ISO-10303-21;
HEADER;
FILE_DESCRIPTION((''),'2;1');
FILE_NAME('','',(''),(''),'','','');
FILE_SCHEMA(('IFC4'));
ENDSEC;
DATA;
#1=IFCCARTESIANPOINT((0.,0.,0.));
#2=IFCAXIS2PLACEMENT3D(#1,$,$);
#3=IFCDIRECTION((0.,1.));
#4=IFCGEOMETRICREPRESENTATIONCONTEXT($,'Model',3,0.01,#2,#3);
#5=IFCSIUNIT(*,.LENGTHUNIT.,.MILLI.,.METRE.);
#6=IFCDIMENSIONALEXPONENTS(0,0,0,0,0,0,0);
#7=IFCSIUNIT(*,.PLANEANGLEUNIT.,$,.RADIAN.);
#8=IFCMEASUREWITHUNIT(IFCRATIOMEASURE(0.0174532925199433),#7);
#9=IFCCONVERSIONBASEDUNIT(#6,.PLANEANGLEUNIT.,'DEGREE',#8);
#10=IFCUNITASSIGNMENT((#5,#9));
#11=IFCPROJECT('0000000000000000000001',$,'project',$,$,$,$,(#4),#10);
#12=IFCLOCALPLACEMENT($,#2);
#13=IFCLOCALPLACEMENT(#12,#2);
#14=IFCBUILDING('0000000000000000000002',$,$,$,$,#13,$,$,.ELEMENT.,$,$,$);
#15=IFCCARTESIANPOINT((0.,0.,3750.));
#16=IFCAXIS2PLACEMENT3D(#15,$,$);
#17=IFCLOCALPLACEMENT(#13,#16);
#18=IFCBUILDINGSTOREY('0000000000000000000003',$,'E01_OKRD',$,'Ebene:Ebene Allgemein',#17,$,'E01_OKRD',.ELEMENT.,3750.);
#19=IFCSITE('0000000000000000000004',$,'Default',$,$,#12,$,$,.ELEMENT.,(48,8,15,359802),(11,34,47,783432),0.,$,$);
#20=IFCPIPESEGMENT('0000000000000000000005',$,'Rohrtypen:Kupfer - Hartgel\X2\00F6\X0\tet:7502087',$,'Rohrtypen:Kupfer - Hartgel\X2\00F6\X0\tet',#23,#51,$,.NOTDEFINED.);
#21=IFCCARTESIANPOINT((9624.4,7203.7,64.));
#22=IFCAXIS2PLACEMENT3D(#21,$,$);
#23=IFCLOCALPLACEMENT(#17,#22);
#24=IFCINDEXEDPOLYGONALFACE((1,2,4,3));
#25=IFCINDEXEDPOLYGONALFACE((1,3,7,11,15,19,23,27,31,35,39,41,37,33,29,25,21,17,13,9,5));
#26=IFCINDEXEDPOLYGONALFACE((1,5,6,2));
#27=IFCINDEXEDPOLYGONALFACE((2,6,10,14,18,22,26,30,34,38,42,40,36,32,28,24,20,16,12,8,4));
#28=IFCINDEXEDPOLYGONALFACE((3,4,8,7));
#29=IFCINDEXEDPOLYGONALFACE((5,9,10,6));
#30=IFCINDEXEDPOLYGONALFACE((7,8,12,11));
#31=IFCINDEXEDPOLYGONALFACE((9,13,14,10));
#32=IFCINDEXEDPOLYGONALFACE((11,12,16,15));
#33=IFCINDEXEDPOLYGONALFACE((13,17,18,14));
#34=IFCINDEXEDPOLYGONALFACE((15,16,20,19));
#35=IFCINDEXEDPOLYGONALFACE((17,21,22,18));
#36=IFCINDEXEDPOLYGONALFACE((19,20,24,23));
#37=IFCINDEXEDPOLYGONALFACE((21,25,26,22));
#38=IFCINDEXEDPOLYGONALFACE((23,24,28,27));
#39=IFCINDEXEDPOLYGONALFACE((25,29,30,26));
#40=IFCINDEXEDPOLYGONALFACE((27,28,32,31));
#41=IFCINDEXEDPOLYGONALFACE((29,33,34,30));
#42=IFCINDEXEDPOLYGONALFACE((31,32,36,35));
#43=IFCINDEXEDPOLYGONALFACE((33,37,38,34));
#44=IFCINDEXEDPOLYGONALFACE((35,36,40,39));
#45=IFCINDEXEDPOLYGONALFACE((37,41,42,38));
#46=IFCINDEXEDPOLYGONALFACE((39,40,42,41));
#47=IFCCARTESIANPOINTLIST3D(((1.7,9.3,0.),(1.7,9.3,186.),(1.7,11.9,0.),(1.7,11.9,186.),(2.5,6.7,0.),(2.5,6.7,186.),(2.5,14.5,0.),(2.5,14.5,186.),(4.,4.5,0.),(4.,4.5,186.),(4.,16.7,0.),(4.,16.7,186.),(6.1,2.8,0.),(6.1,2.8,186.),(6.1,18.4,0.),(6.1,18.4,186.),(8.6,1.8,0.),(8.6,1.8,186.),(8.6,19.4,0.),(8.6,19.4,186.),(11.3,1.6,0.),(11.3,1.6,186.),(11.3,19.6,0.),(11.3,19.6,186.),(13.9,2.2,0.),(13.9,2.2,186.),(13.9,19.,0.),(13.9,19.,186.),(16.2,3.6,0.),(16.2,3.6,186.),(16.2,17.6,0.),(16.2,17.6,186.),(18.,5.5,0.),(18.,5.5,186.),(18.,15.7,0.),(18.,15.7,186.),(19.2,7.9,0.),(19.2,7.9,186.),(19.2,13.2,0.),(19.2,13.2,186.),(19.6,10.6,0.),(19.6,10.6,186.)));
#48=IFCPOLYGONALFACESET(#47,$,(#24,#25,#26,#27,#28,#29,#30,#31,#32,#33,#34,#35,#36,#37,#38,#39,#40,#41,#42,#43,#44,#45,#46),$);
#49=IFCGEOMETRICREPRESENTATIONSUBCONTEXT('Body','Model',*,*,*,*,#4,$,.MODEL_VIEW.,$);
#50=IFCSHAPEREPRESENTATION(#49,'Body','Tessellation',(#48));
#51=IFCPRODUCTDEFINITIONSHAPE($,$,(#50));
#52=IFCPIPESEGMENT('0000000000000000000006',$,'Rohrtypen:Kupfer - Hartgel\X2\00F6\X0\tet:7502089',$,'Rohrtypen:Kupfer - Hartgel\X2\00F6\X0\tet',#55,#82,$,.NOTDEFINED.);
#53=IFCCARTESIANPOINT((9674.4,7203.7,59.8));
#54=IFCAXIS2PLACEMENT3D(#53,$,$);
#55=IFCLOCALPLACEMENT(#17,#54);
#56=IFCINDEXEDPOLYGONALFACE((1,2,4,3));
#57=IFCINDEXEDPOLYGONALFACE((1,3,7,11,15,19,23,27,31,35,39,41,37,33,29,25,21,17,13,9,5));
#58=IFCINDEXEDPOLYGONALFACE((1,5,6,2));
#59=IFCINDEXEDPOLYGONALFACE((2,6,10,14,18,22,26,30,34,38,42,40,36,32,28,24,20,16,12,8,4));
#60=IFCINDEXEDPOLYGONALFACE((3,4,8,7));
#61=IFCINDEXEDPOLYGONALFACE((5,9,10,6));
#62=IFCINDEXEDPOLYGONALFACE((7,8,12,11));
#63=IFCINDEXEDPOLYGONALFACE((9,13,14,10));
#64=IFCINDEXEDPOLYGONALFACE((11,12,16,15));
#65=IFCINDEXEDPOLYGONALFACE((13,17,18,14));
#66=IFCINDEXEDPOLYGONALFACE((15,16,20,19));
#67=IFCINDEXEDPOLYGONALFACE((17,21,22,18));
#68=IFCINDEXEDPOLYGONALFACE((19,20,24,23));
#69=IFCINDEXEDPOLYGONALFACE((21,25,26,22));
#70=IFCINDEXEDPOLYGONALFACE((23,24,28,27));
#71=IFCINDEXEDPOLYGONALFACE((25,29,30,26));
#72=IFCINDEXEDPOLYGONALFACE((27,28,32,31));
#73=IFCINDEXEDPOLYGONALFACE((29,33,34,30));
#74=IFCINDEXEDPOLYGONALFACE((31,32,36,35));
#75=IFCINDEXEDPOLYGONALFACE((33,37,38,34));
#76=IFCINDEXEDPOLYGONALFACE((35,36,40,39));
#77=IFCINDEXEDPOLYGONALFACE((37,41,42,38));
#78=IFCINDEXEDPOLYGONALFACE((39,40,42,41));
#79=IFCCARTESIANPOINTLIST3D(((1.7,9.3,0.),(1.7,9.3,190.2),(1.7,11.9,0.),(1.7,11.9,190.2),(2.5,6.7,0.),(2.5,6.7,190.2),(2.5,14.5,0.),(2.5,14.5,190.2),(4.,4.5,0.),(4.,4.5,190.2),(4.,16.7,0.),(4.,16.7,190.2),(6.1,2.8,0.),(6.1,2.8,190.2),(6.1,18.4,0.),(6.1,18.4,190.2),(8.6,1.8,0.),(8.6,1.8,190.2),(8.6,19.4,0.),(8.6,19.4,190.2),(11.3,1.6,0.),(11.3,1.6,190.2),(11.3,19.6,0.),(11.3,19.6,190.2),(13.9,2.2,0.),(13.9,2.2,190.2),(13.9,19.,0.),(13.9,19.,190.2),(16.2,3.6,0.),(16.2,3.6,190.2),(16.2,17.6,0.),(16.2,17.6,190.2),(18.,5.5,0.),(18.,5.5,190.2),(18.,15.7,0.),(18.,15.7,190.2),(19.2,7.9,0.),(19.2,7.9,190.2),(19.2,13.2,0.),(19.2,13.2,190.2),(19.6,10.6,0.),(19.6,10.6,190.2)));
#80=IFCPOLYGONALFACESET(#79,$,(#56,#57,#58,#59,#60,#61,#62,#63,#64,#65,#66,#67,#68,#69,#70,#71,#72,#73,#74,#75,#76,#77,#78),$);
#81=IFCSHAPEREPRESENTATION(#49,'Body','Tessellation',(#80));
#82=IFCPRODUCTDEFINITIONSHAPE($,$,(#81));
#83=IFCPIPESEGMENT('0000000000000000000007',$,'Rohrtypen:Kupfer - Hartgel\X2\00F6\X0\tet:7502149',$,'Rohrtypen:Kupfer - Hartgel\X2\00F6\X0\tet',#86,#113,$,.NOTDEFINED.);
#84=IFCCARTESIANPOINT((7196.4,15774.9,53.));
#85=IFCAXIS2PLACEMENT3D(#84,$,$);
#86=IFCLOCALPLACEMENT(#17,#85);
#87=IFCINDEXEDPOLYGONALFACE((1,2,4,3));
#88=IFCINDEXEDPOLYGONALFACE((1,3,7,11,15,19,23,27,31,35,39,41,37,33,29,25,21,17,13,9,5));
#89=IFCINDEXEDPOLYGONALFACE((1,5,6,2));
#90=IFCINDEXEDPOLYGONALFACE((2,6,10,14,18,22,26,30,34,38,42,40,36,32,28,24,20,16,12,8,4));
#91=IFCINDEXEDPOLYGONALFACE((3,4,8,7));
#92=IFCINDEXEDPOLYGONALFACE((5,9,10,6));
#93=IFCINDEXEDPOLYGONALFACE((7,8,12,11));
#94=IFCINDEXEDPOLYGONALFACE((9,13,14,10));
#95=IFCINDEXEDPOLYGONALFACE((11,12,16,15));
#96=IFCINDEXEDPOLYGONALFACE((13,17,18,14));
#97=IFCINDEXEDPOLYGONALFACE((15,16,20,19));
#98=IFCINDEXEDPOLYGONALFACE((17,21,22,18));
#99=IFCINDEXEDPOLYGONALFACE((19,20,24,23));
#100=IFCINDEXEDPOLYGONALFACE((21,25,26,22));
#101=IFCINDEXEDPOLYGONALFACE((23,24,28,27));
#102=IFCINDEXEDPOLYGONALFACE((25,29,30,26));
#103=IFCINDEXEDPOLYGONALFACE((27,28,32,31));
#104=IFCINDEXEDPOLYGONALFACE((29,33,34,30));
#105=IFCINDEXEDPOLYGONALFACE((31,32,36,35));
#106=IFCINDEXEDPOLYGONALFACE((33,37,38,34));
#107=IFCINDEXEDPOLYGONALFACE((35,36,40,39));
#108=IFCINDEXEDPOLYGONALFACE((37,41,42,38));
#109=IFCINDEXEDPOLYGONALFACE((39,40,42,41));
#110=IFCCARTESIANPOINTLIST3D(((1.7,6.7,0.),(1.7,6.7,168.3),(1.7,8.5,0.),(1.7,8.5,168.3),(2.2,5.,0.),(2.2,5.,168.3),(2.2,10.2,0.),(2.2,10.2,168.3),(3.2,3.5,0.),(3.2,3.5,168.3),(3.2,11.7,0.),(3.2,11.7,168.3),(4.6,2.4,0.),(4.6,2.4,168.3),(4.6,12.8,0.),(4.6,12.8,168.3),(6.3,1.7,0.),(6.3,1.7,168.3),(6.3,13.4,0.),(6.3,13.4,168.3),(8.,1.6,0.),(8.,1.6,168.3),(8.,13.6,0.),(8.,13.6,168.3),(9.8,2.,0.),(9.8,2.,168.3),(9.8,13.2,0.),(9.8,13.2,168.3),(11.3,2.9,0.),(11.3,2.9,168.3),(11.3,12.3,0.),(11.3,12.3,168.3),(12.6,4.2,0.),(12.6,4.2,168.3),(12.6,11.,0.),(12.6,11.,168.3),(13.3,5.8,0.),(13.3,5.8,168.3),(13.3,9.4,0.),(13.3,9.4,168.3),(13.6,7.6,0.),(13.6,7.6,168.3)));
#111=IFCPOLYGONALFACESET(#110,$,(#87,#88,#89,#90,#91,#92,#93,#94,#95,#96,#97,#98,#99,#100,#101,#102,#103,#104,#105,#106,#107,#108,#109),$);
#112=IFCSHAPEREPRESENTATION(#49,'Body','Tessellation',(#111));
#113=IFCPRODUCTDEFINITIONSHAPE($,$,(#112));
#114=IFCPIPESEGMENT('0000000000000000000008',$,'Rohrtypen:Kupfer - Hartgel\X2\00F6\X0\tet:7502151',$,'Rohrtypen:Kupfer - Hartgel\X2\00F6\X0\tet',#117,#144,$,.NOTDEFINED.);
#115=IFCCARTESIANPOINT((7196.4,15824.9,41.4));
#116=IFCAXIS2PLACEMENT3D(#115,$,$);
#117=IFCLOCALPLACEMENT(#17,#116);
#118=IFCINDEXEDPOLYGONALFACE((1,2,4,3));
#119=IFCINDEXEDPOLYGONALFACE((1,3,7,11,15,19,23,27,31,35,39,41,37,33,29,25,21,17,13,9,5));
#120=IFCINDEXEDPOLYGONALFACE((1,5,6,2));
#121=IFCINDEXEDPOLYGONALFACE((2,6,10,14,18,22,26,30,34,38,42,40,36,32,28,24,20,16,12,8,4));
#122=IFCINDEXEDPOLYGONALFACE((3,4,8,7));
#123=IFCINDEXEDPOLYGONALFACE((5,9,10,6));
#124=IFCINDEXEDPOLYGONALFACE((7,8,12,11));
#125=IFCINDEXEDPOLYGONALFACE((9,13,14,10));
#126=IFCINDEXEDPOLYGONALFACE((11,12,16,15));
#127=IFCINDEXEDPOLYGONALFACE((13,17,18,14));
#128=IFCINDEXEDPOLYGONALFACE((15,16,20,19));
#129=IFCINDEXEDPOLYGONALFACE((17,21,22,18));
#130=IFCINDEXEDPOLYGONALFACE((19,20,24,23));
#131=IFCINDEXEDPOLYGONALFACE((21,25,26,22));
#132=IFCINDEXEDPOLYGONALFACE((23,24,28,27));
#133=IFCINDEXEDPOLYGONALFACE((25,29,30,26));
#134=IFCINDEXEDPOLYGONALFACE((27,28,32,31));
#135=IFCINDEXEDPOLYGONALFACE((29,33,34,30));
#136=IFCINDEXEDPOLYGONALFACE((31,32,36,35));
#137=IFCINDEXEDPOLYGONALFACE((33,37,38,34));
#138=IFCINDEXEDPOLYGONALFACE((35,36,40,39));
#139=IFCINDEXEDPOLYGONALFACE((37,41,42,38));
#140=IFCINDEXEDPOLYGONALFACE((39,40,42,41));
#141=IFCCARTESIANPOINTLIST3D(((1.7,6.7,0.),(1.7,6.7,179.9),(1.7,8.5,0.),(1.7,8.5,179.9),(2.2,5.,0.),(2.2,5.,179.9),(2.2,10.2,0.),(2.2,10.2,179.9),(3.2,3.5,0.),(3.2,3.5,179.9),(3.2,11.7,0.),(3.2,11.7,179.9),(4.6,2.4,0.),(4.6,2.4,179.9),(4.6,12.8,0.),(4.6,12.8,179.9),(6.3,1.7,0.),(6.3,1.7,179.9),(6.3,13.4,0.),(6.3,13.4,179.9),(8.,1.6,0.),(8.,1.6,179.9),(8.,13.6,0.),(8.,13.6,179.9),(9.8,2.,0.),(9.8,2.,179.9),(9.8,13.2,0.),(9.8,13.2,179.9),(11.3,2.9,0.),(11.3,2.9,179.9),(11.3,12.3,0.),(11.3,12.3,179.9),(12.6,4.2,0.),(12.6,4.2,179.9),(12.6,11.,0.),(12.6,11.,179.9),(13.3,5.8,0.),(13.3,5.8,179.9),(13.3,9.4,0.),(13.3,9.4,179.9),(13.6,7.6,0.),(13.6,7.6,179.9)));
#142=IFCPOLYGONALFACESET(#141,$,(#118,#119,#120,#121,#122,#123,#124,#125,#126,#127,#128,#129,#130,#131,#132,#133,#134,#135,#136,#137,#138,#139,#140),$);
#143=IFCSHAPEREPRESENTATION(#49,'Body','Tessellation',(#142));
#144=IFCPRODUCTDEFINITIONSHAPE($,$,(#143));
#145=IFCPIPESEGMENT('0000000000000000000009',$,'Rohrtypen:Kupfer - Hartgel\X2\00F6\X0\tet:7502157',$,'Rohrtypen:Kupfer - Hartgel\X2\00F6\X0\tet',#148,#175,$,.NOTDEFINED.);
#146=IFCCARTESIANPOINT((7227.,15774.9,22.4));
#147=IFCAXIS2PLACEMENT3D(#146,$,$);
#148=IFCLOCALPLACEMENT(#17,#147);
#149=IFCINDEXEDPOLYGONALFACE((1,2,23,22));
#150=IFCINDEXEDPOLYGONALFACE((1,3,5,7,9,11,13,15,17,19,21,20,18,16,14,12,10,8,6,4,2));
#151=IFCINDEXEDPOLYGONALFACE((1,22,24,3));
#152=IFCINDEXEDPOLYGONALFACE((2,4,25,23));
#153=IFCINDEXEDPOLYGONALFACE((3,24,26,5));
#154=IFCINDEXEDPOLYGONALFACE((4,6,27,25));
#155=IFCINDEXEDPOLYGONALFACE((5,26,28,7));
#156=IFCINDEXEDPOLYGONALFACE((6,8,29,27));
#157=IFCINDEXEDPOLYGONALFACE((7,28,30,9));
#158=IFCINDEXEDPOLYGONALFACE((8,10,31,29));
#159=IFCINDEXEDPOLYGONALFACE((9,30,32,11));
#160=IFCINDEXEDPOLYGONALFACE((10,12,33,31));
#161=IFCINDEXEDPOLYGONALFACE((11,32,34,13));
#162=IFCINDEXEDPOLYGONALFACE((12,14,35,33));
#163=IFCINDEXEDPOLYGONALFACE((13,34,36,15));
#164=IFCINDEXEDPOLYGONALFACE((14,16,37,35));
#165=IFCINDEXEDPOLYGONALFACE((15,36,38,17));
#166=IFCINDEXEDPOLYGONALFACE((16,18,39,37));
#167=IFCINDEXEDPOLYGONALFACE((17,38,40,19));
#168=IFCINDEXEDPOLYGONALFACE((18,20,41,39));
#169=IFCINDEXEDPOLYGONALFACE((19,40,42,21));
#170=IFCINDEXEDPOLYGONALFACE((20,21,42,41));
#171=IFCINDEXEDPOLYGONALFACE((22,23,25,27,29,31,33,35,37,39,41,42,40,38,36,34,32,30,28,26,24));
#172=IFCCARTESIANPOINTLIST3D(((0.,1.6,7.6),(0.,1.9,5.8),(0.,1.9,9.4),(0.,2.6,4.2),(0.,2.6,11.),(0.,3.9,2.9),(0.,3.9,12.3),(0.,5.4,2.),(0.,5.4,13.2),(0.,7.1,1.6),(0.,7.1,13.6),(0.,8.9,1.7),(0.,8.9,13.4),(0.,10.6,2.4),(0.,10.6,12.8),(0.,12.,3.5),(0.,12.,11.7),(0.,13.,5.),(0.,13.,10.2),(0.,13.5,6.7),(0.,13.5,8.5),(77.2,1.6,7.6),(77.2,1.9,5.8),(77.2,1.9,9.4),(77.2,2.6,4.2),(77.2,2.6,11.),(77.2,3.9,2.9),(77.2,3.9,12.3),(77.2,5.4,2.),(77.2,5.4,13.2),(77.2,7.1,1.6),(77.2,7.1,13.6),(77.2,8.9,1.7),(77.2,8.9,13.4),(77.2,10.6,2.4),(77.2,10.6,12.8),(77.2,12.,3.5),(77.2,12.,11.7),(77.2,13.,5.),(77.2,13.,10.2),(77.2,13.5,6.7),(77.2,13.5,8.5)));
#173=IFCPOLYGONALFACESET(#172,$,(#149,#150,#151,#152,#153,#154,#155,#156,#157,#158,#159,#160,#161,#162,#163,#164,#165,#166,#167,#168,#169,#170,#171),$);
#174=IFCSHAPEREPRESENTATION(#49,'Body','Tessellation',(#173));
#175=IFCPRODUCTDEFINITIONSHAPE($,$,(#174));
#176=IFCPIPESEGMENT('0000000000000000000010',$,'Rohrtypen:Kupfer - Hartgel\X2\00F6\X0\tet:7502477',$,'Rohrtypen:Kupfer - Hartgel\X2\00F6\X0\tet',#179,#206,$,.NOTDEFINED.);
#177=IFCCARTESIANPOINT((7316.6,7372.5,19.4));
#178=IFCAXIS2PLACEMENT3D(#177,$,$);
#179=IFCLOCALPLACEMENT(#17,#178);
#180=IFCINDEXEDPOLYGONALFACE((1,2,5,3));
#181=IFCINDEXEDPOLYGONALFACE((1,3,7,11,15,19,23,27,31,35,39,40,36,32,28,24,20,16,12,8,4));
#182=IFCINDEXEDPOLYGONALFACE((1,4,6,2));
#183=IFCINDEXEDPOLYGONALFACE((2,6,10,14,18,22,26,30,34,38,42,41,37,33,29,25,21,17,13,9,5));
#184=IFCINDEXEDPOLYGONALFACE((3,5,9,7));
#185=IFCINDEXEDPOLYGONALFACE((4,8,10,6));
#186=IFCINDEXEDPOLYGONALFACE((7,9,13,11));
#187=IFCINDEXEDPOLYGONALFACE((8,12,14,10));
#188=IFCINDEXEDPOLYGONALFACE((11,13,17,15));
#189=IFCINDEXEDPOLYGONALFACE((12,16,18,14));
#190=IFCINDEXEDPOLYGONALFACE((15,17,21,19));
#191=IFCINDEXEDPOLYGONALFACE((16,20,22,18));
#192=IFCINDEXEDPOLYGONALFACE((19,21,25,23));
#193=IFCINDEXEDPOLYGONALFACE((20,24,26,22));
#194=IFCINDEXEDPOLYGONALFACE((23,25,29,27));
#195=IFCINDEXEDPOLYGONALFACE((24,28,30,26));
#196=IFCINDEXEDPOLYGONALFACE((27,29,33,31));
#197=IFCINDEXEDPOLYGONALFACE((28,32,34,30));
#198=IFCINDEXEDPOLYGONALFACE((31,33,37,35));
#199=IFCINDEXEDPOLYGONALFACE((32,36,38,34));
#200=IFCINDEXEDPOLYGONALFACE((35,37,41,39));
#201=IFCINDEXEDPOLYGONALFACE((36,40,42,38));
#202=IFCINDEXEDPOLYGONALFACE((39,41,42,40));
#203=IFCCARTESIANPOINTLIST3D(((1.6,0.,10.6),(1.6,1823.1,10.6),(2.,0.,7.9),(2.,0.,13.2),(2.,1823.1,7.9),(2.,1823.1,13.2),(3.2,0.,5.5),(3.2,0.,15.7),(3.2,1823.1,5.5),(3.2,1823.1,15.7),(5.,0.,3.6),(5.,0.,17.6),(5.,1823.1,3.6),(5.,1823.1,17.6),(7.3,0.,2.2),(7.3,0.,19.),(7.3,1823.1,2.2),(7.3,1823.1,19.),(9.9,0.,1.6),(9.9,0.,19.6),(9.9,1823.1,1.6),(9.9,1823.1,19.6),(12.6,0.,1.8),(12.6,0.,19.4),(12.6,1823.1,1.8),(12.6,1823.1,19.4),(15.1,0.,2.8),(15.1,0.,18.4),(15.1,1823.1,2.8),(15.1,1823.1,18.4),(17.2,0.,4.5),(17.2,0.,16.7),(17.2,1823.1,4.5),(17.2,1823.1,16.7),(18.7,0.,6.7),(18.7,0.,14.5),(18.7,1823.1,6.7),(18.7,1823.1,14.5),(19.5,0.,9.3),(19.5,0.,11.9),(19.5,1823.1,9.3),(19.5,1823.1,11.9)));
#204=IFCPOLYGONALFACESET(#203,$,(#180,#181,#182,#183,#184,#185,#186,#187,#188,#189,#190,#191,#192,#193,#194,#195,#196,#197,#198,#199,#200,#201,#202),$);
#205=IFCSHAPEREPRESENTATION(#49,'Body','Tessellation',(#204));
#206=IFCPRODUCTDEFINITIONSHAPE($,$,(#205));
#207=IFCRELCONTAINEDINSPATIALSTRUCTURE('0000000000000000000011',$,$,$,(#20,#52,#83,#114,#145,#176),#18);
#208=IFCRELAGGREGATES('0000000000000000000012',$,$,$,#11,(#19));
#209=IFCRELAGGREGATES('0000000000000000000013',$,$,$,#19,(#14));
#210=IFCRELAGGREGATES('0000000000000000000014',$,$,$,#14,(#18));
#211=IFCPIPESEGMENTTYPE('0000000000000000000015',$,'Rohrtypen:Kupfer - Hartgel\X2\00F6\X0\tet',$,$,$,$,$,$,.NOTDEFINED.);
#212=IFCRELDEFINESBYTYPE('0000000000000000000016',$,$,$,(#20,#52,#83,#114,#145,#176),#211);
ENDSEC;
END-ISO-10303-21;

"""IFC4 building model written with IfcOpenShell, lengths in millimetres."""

from ifc_helpers import new_model, entity, si_unit, converted_unit, direction, frame, frame_2d, origin, origin_2d_with_axis, place, context, subcontext, project, spatial, circle, extrude, type_object, element, save


model = new_model("IFC4")

# Units and contexts
model_context = context("Model", 3, precision=0.01, world=origin(), true_north=direction((0.0, 1.0)))
body_context = subcontext(model_context, "Body", "Model", "MODEL_VIEW")
ifc_project = project(units=[si_unit("LENGTHUNIT", "METRE", prefix="MILLI"), converted_unit("PLANEANGLEUNIT", "DEGREE", entity("IfcRatioMeasure", 0.0174532925199433), si_unit("PLANEANGLEUNIT", "RADIAN"), dimensions=[0, 0, 0, 0, 0, 0, 0])], contexts=[model_context])

# Site, building, storey
site_placement = place(None, origin())
site = spatial("IfcSite", under=ifc_project, at=site_placement, Name="Default", CompositionType="ELEMENT", RefLatitude=(48, 8, 15, 359802), RefLongitude=(11, 34, 47, 783432), RefElevation=0.0)
building_placement = place(site_placement, origin())
building = spatial("IfcBuilding", under=site, at=building_placement, CompositionType="ELEMENT")
storey_placement = place(building_placement, frame((0.0, 0.0, 3750.0)))
storey = spatial("IfcBuildingStorey", under=building, at=storey_placement, Name="E01_OKRD", ObjectType="Ebene:Ebene Allgemein", LongName="E01_OKRD", CompositionType="ELEMENT", Elevation=3750.0)

# Pipe segments
pipe_segment_type = type_object("IfcPipeSegmentType", Name="Rohrtypen:Kupfer - Hartgelötet", PredefinedType="NOTDEFINED")
pipe_segment_1_placement = place(storey_placement, frame((9624.4, 7203.7, 64.0)))
element("IfcPipeSegment", 1, at=pipe_segment_1_placement, inside=storey, type_object=pipe_segment_type, Name="Rohrtypen:Kupfer - Hartgelötet:7502087", ObjectType="Rohrtypen:Kupfer - Hartgelötet", PredefinedType="NOTDEFINED", context=body_context, shape_type="SweptSolid", body=[
    extrude(circle(Radius=9.0, at=origin_2d_with_axis()), frame((10.6, 10.6, 0.0)), (0.0, 0.0, 1.0), 186.0),
])
pipe_segment_2_placement = place(storey_placement, frame((9674.4, 7203.7, 59.8)))
element("IfcPipeSegment", 2, at=pipe_segment_2_placement, inside=storey, type_object=pipe_segment_type, Name="Rohrtypen:Kupfer - Hartgelötet:7502089", ObjectType="Rohrtypen:Kupfer - Hartgelötet", PredefinedType="NOTDEFINED", context=body_context, shape_type="SweptSolid", body=[
    extrude(circle(Radius=9.0, at=origin_2d_with_axis()), frame((10.6, 10.6, 0.0)), (0.0, 0.0, 1.0), 190.2),
])
pipe_segment_3_placement = place(storey_placement, frame((7196.4, 15774.9, 53.0)))
element("IfcPipeSegment", 3, at=pipe_segment_3_placement, inside=storey, type_object=pipe_segment_type, Name="Rohrtypen:Kupfer - Hartgelötet:7502149", ObjectType="Rohrtypen:Kupfer - Hartgelötet", PredefinedType="NOTDEFINED", context=body_context, shape_type="SweptSolid", body=[
    extrude(circle(Radius=6.0, at=origin_2d_with_axis()), frame((7.6, 7.6, 0.0)), (0.0, 0.0, 1.0), 168.3),
])
pipe_segment_4_placement = place(storey_placement, frame((7196.4, 15824.9, 41.4)))
element("IfcPipeSegment", 4, at=pipe_segment_4_placement, inside=storey, type_object=pipe_segment_type, Name="Rohrtypen:Kupfer - Hartgelötet:7502151", ObjectType="Rohrtypen:Kupfer - Hartgelötet", PredefinedType="NOTDEFINED", context=body_context, shape_type="SweptSolid", body=[
    extrude(circle(Radius=6.0, at=frame_2d((0.0, 0.0), x_axis=(1.0, 0.0))), frame((7.6, 7.6, 0.0)), (0.0, 0.0, 1.0), 179.9),
])
pipe_segment_5_placement = place(storey_placement, frame((7227.0, 15774.9, 22.4)))
element("IfcPipeSegment", 5, at=pipe_segment_5_placement, inside=storey, type_object=pipe_segment_type, Name="Rohrtypen:Kupfer - Hartgelötet:7502157", ObjectType="Rohrtypen:Kupfer - Hartgelötet", PredefinedType="NOTDEFINED", context=body_context, shape_type="SweptSolid", body=[
    extrude(circle(Radius=6.0, at=frame_2d((0.0, 0.0), x_axis=(1.0, 0.0))), frame((0.0, 7.6, 7.6), z_axis=(1.0, 0.0, 0.0), x_axis=(0.0, -1.0, 0.0)), (0.0, 0.0, 1.0), 77.2),
])
pipe_segment_6_placement = place(storey_placement, frame((7316.6, 7372.5, 19.4)))
element("IfcPipeSegment", 6, at=pipe_segment_6_placement, inside=storey, type_object=pipe_segment_type, Name="Rohrtypen:Kupfer - Hartgelötet:7502477", ObjectType="Rohrtypen:Kupfer - Hartgelötet", PredefinedType="NOTDEFINED", context=body_context, shape_type="SweptSolid", body=[
    extrude(circle(Radius=9.0, at=origin_2d_with_axis()), frame((10.6, 0.0, 10.6), z_axis=(0.0, 1.0, 0.0), x_axis=(-1.0, 0.0, 0.0)), (0.0, 0.0, 1.0), 1823.1),
])

save(model, "model.ifc")
